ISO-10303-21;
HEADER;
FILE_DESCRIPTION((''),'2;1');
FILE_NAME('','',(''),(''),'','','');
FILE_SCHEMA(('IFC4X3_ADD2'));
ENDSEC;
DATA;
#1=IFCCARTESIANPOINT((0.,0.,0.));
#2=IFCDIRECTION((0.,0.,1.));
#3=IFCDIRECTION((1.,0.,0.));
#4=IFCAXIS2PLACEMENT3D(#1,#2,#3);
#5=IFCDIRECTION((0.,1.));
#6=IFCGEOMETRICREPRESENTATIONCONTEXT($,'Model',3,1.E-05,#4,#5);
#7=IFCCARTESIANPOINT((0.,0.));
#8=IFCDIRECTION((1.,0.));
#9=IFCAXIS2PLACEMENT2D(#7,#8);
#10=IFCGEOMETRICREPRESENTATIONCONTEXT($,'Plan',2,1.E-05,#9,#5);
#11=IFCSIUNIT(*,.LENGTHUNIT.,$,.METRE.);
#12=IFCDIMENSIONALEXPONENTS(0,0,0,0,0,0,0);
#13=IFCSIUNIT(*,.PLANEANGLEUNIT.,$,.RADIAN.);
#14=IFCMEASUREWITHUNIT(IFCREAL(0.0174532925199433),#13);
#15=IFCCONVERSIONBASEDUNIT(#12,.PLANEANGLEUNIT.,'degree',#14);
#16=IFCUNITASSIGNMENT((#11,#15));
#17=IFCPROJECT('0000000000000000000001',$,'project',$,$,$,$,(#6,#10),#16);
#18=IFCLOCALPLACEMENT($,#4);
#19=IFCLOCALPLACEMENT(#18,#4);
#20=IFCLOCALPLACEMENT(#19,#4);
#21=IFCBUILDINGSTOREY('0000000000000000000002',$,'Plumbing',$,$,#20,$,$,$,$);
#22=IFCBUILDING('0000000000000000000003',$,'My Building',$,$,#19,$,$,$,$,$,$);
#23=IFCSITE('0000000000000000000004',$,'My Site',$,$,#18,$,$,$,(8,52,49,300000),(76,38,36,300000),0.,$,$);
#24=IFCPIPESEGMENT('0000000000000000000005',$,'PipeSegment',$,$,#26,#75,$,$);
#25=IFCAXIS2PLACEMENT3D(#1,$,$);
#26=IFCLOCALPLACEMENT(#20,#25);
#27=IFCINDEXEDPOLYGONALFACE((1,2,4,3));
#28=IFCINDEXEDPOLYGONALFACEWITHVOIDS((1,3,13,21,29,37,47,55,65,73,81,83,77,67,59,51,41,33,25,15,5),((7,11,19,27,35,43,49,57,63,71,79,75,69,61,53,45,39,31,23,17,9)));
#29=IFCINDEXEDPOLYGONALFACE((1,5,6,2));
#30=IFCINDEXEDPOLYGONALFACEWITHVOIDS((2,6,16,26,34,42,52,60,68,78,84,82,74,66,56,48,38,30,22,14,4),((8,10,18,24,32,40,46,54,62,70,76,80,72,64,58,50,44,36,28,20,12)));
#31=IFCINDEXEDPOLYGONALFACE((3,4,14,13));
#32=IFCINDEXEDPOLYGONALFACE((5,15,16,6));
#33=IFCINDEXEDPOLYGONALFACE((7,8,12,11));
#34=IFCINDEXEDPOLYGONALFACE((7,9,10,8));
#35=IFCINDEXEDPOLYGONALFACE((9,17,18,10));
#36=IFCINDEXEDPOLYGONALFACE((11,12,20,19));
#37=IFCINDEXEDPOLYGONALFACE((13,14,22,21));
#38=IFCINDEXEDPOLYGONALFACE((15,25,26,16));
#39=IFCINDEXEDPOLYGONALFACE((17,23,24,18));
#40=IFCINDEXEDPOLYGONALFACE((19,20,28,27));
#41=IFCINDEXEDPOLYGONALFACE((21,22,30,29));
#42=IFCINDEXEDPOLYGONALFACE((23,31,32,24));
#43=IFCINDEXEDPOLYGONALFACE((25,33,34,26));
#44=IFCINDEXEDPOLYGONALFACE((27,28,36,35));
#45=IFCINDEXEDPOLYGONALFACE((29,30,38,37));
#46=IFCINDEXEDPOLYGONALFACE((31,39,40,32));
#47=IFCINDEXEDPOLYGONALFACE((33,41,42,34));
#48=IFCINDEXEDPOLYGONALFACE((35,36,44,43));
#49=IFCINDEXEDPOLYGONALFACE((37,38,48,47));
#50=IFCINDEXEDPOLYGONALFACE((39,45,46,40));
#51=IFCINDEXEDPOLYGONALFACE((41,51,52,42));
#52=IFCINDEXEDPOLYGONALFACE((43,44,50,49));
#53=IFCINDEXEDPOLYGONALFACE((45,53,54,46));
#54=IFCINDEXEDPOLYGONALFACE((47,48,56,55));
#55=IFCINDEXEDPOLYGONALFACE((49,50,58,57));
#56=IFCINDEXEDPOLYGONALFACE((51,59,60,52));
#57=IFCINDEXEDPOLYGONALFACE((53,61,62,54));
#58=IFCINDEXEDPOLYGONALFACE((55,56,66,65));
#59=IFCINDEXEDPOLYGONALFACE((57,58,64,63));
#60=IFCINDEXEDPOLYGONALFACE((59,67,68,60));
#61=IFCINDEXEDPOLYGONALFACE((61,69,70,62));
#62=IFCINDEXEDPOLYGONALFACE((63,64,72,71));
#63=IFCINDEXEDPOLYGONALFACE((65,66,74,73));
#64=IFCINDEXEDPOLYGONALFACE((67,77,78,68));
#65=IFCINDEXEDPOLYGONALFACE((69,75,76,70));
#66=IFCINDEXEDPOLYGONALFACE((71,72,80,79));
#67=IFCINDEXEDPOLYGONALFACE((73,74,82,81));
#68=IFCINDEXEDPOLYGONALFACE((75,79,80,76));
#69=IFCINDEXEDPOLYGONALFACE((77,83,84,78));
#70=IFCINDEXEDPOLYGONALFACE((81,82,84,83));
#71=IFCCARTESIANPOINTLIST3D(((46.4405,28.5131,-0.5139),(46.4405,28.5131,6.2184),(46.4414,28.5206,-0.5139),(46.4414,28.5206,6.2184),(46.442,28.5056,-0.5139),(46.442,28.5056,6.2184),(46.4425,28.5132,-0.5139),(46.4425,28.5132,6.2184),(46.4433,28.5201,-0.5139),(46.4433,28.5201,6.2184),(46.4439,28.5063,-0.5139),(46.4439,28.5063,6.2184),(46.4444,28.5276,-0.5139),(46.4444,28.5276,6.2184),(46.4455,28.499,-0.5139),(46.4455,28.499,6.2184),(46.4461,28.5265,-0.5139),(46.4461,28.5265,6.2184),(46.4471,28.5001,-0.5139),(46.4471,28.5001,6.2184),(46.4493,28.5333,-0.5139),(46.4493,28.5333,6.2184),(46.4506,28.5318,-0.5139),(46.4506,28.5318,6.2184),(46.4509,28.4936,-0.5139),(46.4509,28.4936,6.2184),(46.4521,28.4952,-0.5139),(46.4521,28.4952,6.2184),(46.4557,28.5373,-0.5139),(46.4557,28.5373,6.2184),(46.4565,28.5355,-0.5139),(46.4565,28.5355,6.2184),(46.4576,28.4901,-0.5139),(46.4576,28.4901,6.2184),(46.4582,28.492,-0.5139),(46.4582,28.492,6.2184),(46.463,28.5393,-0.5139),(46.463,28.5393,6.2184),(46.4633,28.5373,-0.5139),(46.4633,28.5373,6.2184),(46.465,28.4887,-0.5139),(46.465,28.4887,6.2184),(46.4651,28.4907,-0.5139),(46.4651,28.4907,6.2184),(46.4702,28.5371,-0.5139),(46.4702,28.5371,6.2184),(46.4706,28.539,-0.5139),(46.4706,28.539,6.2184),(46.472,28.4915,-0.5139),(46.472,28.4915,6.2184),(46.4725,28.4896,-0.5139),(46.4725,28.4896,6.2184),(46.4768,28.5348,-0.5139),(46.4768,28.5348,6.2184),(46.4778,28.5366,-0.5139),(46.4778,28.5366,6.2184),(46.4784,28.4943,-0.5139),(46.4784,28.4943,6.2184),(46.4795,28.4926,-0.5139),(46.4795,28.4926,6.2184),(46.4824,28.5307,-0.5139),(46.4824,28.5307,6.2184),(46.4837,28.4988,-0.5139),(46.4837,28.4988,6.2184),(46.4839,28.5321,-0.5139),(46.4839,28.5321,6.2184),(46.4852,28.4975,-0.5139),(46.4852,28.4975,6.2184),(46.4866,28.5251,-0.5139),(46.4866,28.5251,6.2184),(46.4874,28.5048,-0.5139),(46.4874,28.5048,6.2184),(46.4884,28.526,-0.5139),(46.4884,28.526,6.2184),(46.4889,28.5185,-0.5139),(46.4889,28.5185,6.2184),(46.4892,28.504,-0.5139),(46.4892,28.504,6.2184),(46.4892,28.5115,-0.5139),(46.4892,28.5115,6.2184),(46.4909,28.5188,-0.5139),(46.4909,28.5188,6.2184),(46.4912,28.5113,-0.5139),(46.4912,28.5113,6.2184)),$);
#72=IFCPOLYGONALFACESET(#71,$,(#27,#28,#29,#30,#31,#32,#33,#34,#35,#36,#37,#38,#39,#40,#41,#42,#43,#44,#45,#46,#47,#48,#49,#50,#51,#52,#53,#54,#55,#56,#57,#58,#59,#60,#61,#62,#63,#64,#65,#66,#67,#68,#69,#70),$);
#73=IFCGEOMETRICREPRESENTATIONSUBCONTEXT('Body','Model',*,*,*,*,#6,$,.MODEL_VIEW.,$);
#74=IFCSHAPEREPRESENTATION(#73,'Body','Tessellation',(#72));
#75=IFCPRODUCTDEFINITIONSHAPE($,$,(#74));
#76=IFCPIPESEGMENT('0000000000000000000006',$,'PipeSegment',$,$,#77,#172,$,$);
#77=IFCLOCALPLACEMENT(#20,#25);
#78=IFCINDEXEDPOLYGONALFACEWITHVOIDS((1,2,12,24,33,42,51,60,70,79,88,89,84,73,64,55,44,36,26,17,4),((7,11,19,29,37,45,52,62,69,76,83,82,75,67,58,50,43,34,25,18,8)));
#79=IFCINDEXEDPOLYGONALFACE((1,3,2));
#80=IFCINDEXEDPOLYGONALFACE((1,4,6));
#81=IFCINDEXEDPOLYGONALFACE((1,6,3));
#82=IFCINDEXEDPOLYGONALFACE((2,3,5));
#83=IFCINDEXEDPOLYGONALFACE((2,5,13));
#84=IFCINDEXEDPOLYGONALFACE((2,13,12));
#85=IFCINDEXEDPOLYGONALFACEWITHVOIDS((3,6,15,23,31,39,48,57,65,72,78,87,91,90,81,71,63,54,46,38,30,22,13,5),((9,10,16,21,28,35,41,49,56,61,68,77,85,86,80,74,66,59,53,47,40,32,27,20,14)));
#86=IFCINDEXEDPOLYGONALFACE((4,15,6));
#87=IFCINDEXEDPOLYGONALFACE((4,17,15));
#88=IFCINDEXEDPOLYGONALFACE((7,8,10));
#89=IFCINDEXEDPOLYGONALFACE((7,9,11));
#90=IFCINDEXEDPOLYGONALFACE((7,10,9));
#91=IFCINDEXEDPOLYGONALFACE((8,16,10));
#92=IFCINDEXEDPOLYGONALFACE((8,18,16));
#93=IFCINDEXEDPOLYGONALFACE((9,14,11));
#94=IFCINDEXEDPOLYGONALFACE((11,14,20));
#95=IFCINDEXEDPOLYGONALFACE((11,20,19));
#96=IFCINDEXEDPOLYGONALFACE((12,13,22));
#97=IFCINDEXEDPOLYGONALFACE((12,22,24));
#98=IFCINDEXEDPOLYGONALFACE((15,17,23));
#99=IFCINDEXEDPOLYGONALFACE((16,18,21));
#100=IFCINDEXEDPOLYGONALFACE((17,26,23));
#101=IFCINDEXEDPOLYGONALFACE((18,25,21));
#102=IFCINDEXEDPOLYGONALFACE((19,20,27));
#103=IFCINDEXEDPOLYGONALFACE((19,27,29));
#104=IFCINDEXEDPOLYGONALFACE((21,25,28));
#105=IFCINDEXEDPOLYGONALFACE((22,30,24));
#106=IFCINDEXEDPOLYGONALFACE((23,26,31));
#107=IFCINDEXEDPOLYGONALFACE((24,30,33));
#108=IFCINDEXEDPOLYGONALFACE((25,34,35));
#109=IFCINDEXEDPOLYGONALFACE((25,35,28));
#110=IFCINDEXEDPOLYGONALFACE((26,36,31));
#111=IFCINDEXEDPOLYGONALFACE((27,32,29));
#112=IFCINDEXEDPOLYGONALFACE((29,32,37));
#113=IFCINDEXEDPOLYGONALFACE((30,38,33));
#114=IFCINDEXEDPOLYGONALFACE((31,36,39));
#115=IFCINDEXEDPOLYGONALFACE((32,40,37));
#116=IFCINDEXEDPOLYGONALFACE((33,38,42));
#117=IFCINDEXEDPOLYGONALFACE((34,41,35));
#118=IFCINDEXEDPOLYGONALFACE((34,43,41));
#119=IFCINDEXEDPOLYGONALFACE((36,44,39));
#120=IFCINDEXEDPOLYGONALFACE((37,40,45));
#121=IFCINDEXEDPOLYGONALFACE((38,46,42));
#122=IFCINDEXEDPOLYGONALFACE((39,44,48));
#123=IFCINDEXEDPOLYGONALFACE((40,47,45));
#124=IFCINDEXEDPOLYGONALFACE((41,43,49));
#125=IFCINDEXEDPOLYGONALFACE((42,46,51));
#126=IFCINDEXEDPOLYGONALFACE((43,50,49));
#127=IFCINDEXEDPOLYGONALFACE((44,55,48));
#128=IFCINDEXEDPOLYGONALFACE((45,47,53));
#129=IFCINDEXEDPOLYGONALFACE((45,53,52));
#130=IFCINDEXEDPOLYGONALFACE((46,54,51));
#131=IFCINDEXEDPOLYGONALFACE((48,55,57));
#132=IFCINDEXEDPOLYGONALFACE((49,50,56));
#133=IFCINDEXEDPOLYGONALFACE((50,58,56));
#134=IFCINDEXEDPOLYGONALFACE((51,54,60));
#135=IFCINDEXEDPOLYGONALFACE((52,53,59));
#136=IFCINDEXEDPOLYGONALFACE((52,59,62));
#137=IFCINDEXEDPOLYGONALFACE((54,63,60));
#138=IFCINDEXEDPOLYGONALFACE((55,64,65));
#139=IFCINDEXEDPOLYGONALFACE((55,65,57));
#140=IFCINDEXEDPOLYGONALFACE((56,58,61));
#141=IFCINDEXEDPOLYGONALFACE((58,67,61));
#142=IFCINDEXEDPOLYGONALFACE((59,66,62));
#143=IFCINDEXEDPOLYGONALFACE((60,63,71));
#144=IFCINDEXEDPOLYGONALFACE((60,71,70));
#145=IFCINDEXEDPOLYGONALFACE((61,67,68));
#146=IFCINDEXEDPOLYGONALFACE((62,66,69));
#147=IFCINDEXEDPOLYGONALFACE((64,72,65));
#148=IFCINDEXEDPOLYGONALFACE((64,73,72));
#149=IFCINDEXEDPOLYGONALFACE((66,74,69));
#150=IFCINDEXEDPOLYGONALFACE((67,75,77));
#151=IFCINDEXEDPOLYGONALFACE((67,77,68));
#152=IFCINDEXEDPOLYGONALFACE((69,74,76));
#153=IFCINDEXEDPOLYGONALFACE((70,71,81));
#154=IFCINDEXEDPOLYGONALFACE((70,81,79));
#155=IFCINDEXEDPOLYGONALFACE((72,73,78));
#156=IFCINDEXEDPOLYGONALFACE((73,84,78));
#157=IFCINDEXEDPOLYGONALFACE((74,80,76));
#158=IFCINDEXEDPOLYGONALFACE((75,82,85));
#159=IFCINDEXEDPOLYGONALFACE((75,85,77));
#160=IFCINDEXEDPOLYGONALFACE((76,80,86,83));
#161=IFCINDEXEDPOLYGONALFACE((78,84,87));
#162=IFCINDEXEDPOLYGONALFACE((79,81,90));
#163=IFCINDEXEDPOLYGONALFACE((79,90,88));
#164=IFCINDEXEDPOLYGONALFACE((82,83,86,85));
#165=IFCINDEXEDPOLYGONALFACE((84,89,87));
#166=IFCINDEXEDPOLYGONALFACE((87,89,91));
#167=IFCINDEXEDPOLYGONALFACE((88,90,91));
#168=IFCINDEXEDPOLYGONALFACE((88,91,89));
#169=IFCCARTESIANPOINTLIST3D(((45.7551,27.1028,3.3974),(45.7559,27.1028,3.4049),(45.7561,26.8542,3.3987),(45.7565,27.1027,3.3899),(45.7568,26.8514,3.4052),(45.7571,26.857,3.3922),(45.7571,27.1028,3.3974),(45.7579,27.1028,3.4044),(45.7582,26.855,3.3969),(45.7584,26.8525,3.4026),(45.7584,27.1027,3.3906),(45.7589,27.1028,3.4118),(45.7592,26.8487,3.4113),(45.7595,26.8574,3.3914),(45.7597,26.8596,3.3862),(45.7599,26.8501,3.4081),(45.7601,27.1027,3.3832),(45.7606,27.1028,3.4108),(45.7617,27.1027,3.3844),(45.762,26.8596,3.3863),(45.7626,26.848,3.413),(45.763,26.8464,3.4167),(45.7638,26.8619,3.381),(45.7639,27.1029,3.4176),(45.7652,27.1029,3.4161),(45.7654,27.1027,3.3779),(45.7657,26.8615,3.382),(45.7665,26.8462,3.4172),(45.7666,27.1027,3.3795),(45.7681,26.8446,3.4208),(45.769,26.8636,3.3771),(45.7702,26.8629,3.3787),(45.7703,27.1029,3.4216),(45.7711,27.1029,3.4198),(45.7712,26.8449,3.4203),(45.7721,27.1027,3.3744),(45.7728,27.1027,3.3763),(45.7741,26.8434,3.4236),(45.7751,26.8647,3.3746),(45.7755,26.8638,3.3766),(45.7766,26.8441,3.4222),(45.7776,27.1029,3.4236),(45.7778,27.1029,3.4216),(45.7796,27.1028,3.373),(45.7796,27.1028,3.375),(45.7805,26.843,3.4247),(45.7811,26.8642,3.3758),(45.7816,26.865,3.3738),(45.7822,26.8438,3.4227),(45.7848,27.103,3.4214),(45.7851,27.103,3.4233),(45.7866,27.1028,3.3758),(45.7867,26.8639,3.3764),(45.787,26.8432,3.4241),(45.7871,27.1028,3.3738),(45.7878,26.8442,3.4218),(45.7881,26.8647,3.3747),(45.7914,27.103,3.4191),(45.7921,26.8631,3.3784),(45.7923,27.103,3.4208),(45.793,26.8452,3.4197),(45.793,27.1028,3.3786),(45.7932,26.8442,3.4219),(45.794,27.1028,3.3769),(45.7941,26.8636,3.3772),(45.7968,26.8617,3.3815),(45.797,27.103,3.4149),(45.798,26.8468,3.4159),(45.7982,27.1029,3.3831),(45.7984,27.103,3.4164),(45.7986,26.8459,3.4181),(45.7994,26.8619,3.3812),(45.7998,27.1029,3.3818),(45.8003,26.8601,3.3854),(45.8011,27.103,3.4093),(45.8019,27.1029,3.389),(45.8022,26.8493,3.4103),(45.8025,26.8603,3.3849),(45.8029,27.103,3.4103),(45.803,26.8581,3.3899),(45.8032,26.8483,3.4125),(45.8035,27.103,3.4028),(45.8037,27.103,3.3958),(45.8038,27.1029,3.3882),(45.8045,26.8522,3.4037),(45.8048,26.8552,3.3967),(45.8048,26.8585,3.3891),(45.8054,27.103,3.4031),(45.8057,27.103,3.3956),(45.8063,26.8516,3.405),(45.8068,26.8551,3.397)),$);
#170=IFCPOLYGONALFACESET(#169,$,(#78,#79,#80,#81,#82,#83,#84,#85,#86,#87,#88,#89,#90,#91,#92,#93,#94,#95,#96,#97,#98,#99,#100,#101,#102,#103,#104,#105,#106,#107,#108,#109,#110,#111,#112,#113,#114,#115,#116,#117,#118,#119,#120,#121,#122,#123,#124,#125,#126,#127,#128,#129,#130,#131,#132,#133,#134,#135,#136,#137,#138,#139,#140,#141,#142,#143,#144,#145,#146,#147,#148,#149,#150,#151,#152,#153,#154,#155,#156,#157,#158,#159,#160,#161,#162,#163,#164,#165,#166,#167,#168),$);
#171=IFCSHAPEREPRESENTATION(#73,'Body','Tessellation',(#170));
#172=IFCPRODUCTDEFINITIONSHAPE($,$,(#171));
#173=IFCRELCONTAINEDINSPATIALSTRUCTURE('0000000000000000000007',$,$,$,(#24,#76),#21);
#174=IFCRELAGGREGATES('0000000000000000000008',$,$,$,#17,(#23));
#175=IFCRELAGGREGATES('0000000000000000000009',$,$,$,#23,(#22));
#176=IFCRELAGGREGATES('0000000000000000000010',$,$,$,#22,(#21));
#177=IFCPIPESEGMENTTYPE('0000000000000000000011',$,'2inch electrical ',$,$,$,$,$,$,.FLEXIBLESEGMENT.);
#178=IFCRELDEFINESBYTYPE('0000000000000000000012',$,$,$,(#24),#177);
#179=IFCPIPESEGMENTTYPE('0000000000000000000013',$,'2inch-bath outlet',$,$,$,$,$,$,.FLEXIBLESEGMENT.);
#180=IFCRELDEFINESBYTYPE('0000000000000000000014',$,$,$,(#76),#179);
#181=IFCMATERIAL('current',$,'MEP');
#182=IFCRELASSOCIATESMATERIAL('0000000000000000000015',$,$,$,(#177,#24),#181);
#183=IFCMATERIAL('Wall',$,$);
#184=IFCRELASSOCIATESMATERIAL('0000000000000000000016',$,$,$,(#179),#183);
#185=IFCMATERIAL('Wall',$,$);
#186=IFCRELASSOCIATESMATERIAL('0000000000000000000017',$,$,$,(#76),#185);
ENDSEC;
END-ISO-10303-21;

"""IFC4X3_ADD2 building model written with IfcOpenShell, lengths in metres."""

from ifc_helpers import new_model, entity, si_unit, converted_unit, direction, frame, origin_with_axes, origin_2d_with_axis, place, context, subcontext, project, spatial, hollow_circle, extrude, clip, halfspace, material, material_profile, profile_set, profile_usage, type_object, element, save


model = new_model("IFC4X3_ADD2")

# Units and contexts
model_context = context("Model", 3, precision=1e-05, world=origin_with_axes(), true_north=direction((0.0, 1.0)))
plan_context = context("Plan", 2, precision=1e-05, world=origin_2d_with_axis(), true_north=direction((0.0, 1.0)))
body_context = subcontext(model_context, "Body", "Model", "MODEL_VIEW")
ifc_project = project(units=[si_unit("LENGTHUNIT", "METRE"), converted_unit("PLANEANGLEUNIT", "degree", entity("IfcReal", 0.0174532925199433), si_unit("PLANEANGLEUNIT", "RADIAN"), dimensions=[0, 0, 0, 0, 0, 0, 0])], contexts=[model_context, plan_context])

# Site, building, storey
site_placement = place(None, origin_with_axes())
site = spatial("IfcSite", under=ifc_project, at=site_placement, Name="My Site", RefLatitude=(8, 52, 49, 300000), RefLongitude=(76, 38, 36, 300000), RefElevation=0.0)
building_placement = place(site_placement, origin_with_axes())
building = spatial("IfcBuilding", under=site, at=building_placement, Name="My Building")
storey_placement = place(building_placement, origin_with_axes())
storey = spatial("IfcBuildingStorey", under=building, at=storey_placement, Name="Plumbing")

# Pipe segments
ifc_material_1 = material(Name="current", Category="MEP")
ifc_material_profile_1 = material_profile(ifc_material_1, hollow_circle(Radius=0.0254, WallThickness=0.002))
ifc_profile_set_1 = profile_set([ifc_material_profile_1], Name="current")
ifc_profile_usage_1 = profile_usage(ifc_profile_set_1, cardinal=5)
pipe_segment_type_1 = type_object("IfcPipeSegmentType", Name="2inch electrical ", PredefinedType="FLEXIBLESEGMENT", material=ifc_profile_set_1)
pipe_segment_1_placement = place(storey_placement, frame((46.4659, 28.5141, -0.5139), z_axis=(0.0, 0.0, 1.0), x_axis=(0.917307, -0.39818, 0.0)))
element("IfcPipeSegment", 1, at=pipe_segment_1_placement, inside=storey, type_object=pipe_segment_type_1, material=ifc_profile_usage_1, Name="PipeSegment", context=body_context, shape_type="SweptSolid", body=[
    extrude(hollow_circle(Radius=0.0254, WallThickness=0.002), origin_with_axes(), (0.0, 0.0, 1.0), 6.7323),
])
ifc_material_2 = material(Name="Wall")
ifc_material_profile_2 = material_profile(ifc_material_2, hollow_circle(Radius=0.0254, WallThickness=0.002))
ifc_profile_set_2 = profile_set([ifc_material_profile_2], Name="graywater")
ifc_profile_usage_2 = profile_usage(ifc_profile_set_2, cardinal=5)
ifc_material_3 = material(Name="Wall")
ifc_material_profile_3 = material_profile(ifc_material_3, hollow_circle(Radius=0.0254, WallThickness=0.002))
ifc_profile_set_3 = profile_set([ifc_material_profile_3], Name="graywater")
pipe_segment_type_2 = type_object("IfcPipeSegmentType", Name="2inch-bath outlet", PredefinedType="FLEXIBLESEGMENT", material=ifc_profile_set_3)
pipe_segment_2_placement = place(storey_placement, frame((45.7805, 27.1029, 3.3984), z_axis=(0.004219, -0.999985, 0.003595), x_axis=(0.917305, 0.002439, -0.398179)))
element("IfcPipeSegment", 2, at=pipe_segment_2_placement, inside=storey, type_object=pipe_segment_type_2, material=ifc_profile_usage_2, Name="PipeSegment", context=body_context, shape_type="Clipping", body=[
    clip(extrude(hollow_circle(Radius=0.0254, WallThickness=0.002), origin_with_axes(), (0.0, 0.0, 1.0), 0.2997), halfspace(frame((1.3675, 0.5738, 0.2432), z_axis=(0.158546, -0.368844, 0.915869), x_axis=(-0.91872, -0.394909, 0.0)), False)),
])

save(model, "model.ifc")
